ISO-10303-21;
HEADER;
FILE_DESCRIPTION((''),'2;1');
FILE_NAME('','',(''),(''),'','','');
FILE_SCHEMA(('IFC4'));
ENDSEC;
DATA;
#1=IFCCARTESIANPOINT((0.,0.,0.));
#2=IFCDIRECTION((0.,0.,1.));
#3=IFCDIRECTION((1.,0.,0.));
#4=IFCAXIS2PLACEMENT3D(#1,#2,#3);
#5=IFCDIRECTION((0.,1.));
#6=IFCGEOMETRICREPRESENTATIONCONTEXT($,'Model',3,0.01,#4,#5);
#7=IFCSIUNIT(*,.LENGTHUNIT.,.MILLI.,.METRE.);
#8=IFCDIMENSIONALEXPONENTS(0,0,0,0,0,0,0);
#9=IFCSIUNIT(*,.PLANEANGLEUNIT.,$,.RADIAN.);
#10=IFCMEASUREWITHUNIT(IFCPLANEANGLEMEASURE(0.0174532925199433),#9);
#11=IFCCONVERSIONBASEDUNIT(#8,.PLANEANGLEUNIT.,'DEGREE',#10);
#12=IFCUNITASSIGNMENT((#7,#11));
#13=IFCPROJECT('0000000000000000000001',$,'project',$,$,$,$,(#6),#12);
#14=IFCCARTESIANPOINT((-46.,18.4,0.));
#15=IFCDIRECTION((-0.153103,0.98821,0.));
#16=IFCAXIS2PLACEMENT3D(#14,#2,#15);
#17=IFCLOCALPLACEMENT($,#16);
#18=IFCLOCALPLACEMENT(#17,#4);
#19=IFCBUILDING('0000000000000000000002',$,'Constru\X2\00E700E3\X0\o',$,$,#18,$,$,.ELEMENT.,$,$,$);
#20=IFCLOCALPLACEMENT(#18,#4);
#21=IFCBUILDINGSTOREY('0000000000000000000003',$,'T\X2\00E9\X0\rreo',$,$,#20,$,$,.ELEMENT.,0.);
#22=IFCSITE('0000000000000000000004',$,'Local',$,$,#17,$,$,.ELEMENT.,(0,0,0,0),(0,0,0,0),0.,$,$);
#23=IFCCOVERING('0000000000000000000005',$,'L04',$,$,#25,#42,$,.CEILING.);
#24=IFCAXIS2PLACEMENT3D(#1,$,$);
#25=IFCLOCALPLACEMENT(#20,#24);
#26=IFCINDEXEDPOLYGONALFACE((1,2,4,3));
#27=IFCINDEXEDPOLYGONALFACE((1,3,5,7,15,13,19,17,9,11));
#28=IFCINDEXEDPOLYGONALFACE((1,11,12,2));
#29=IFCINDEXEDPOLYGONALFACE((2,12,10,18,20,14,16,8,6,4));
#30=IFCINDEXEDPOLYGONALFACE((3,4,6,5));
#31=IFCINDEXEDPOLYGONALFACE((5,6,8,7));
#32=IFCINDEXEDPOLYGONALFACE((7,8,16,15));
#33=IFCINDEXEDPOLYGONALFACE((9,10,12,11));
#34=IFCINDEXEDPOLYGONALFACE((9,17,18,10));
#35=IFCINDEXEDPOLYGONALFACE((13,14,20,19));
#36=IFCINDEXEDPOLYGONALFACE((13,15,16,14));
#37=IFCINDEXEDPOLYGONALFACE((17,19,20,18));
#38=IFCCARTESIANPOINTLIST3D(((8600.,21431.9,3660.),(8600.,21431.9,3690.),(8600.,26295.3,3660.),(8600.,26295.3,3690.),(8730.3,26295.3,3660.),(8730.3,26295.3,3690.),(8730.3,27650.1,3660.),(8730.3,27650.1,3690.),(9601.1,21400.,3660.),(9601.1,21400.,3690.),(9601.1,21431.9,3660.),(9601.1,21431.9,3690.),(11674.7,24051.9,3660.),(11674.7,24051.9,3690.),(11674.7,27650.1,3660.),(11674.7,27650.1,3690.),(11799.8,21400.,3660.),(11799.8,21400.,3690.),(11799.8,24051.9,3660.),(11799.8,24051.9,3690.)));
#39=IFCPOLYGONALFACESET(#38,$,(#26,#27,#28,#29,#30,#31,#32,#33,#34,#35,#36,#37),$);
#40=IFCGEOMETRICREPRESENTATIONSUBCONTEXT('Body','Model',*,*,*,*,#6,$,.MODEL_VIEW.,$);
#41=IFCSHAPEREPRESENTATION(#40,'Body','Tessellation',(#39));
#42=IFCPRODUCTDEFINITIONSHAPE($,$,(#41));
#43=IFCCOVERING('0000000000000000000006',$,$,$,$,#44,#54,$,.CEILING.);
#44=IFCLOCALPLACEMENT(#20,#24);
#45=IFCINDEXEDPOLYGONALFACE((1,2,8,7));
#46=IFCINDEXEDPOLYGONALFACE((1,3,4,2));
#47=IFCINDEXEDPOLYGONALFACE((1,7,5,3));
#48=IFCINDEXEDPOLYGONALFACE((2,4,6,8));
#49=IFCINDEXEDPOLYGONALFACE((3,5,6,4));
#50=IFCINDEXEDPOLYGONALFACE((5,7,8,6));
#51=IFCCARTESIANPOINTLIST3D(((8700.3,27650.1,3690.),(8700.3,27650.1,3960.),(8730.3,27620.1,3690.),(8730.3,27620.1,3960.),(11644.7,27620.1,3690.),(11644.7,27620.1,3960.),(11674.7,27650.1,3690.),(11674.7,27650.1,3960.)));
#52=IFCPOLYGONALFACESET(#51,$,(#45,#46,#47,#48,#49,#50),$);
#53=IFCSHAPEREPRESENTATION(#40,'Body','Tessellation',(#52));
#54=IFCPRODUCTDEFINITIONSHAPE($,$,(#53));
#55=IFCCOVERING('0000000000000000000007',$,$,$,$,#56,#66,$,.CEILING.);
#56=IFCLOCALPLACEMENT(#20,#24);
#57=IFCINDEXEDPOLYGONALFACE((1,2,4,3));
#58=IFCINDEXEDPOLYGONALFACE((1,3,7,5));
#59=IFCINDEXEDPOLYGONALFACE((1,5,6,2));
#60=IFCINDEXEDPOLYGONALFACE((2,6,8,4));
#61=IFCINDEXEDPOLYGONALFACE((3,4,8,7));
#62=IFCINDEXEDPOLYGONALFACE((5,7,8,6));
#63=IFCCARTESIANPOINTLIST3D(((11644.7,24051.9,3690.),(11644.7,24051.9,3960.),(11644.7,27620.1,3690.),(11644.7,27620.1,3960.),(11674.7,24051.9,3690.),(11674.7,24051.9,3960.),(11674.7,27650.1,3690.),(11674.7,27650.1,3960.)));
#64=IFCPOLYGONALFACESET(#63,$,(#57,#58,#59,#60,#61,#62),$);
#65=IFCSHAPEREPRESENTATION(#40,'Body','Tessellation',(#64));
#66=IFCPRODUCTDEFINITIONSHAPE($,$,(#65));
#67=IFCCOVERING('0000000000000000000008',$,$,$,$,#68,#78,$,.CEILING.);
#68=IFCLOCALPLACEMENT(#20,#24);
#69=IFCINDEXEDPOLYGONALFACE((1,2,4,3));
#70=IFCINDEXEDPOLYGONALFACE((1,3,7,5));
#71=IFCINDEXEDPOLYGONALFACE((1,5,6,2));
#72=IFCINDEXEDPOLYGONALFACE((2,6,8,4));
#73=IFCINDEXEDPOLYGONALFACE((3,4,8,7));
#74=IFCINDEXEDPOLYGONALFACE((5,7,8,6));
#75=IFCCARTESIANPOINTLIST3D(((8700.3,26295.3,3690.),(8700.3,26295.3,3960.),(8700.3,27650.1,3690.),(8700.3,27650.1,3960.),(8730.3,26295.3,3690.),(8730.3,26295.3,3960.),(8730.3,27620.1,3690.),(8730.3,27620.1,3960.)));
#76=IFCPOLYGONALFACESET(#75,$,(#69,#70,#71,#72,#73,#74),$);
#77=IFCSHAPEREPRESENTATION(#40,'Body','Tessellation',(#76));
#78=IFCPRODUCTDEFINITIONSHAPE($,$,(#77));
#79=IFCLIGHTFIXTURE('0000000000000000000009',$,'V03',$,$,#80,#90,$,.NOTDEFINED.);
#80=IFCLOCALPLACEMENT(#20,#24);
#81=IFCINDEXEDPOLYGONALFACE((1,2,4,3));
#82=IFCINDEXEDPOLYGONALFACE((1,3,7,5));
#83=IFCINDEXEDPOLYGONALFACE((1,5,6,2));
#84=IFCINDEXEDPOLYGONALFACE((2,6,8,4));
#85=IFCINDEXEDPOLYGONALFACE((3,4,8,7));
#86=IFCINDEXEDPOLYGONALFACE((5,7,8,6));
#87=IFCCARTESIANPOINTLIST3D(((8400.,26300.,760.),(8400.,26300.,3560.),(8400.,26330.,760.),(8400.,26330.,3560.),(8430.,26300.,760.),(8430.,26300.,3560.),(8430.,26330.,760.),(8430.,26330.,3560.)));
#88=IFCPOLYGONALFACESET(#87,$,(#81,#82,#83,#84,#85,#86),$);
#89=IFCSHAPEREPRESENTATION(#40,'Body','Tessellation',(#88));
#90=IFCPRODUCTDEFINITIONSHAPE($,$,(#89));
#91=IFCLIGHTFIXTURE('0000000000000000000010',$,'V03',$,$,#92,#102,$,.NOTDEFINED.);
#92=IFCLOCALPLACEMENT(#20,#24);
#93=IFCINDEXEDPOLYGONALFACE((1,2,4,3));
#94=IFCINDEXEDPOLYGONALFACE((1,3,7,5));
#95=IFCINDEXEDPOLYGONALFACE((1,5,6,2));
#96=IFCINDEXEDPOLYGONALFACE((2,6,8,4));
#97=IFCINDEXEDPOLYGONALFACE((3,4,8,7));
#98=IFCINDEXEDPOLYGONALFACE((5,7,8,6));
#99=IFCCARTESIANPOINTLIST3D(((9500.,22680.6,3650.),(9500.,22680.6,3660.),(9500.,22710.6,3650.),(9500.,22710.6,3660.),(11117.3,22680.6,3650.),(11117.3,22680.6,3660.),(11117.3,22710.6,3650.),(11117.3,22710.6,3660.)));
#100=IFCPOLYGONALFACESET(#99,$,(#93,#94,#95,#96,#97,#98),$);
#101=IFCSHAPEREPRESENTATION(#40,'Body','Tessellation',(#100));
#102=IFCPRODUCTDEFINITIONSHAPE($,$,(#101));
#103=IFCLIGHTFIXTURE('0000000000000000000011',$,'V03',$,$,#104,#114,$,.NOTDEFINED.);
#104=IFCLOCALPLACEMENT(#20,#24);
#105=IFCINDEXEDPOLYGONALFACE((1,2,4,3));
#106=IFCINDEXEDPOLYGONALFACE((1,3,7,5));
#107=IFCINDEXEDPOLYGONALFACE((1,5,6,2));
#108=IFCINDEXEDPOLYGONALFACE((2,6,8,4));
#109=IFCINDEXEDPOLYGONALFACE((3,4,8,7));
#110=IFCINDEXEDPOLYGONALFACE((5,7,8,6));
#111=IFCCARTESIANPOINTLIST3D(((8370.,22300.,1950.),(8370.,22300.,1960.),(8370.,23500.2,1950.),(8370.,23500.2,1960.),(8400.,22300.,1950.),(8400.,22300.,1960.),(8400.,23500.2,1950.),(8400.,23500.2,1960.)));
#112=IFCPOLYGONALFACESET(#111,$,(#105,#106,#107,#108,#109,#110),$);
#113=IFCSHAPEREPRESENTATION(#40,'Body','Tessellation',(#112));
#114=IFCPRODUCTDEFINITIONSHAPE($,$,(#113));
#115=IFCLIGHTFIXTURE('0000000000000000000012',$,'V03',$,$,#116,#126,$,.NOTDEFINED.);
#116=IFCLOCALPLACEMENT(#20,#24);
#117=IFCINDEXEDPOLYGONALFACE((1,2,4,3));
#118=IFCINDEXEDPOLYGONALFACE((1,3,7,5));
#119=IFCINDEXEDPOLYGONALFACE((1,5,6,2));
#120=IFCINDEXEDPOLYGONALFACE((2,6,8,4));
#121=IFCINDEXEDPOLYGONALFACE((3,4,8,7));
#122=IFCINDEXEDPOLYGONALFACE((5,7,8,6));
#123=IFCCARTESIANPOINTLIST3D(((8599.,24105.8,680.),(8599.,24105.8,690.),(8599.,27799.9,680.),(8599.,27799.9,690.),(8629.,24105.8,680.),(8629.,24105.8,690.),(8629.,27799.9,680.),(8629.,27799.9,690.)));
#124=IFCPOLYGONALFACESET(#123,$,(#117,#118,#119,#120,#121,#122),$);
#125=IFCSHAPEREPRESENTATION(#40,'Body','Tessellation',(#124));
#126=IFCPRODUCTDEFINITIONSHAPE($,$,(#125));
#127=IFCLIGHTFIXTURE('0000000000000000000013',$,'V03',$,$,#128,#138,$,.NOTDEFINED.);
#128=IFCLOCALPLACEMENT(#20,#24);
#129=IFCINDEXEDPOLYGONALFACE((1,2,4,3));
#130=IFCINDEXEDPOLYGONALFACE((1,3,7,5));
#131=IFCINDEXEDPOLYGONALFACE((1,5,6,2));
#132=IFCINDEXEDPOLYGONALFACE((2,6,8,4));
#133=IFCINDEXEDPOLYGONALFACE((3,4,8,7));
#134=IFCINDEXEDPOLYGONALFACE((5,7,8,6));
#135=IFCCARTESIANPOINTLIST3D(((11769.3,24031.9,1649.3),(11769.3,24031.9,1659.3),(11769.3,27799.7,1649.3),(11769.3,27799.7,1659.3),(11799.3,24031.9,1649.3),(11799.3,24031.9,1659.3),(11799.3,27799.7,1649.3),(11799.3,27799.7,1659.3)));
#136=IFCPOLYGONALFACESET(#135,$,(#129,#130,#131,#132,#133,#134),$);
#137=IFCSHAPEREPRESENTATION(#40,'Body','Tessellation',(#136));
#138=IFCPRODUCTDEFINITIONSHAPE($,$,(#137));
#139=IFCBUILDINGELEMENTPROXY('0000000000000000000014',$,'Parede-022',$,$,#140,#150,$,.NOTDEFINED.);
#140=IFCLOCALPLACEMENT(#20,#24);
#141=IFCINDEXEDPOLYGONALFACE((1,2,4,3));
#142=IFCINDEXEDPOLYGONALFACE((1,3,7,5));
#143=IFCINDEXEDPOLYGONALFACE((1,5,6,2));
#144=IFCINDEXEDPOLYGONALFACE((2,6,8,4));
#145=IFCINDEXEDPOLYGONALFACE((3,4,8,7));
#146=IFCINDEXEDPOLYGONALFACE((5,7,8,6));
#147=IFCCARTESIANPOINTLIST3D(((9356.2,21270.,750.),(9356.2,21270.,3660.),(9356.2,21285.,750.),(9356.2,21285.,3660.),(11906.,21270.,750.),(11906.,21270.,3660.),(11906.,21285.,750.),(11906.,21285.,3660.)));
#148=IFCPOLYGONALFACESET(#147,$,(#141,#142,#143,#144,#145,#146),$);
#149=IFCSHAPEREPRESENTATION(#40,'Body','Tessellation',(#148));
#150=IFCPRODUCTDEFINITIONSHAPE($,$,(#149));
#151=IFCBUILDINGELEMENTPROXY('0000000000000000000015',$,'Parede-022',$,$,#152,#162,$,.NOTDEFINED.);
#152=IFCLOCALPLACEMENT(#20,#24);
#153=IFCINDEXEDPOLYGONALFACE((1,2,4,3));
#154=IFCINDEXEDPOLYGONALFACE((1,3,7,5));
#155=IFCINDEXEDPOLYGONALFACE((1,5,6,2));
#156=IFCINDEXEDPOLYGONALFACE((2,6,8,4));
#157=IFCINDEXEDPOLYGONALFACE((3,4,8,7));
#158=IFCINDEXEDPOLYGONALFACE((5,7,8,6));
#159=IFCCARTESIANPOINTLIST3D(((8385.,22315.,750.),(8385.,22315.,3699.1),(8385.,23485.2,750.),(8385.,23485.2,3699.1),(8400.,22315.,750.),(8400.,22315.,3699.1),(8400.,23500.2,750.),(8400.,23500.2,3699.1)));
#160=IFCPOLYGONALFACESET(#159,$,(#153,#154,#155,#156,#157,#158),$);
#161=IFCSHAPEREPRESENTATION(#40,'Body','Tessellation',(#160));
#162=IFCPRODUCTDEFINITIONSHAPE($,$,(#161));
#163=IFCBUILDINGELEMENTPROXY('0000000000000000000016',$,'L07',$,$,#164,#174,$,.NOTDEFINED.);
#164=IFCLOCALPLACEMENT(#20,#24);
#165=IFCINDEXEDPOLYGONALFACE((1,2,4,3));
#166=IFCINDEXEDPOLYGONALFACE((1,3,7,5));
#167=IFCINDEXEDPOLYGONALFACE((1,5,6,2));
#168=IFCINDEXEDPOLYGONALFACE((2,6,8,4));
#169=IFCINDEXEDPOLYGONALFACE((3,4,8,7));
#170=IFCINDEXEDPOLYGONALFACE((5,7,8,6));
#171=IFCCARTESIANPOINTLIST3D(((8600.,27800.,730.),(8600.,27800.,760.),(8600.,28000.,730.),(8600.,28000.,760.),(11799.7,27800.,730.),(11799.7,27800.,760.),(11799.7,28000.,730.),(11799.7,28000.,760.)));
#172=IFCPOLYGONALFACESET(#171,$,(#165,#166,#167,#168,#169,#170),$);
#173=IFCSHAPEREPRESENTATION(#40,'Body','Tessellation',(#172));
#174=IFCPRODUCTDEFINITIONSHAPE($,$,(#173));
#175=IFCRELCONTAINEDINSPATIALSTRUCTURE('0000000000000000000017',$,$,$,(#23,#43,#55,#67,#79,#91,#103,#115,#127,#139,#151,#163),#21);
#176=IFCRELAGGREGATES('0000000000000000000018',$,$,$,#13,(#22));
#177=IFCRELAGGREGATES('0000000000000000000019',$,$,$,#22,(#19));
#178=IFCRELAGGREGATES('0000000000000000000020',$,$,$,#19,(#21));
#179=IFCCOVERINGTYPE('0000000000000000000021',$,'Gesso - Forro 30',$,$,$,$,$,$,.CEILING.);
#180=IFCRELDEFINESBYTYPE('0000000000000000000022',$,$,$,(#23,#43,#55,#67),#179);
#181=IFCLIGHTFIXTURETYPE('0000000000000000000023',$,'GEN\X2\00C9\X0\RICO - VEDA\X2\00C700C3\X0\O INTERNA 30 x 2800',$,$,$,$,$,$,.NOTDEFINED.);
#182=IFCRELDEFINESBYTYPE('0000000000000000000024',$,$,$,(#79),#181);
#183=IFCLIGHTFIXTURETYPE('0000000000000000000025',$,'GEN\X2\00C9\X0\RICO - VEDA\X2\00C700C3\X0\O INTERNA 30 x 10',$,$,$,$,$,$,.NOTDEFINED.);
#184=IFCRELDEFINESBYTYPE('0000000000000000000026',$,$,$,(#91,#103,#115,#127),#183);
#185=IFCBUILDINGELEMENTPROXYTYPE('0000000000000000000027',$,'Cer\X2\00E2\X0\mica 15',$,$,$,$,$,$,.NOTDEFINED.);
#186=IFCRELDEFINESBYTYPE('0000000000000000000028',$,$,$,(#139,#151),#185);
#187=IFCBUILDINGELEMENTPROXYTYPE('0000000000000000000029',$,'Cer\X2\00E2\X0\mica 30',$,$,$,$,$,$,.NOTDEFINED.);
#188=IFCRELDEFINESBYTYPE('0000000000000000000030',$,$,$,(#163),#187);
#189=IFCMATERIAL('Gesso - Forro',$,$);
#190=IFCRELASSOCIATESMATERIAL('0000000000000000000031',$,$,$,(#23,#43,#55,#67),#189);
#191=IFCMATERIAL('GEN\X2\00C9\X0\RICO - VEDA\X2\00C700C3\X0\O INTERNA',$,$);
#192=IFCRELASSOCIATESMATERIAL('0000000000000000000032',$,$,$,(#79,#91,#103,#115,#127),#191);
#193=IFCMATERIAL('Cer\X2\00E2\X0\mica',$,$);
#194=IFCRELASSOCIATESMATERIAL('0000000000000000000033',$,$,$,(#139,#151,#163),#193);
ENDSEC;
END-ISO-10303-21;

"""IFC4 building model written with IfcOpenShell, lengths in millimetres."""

from ifc_helpers import new_model, entity, si_unit, converted_unit, direction, frame, frame_2d, origin_with_axes, place, context, subcontext, project, spatial, line, indexed_curve, rectangle, outline, extrude, material, type_object, element, save


model = new_model("IFC4")

# Units and contexts
model_context = context("Model", 3, precision=0.01, world=origin_with_axes(), true_north=direction((0.0, 1.0)))
body_context = subcontext(model_context, "Body", "Model", "MODEL_VIEW")
ifc_project = project(units=[si_unit("LENGTHUNIT", "METRE", prefix="MILLI"), converted_unit("PLANEANGLEUNIT", "DEGREE", entity("IfcPlaneAngleMeasure", 0.0174532925199433), si_unit("PLANEANGLEUNIT", "RADIAN"), dimensions=[0, 0, 0, 0, 0, 0, 0])], contexts=[model_context])

# Site, building, storey
site_placement = place(None, frame((-46.0, 18.4, 0.0), z_axis=(0.0, 0.0, 1.0), x_axis=(-0.153103, 0.98821, 0.0)))
site = spatial("IfcSite", under=ifc_project, at=site_placement, Name="Local", CompositionType="ELEMENT", RefLatitude=(0, 0, 0, 0), RefLongitude=(0, 0, 0, 0), RefElevation=0.0)
building_placement = place(site_placement, origin_with_axes())
building = spatial("IfcBuilding", under=site, at=building_placement, Name="Construção", CompositionType="ELEMENT")
storey_placement = place(building_placement, origin_with_axes())
storey = spatial("IfcBuildingStorey", under=building, at=storey_placement, Name="Térreo", CompositionType="ELEMENT", Elevation=0.0)

# Shared definitions
ifc_material_1 = material(Name="GENÉRICO - VEDAÇÃO INTERNA")

# Coverings
ifc_material_2 = material(Name="Gesso - Forro")
covering_type_1 = type_object("IfcCoveringType", Name="Gesso - Forro 30", PredefinedType="CEILING")
covering_1_placement = place(storey_placement, frame((8730.3, 26295.3, 3690.0), z_axis=(0.0, 0.0, 1.0), x_axis=(1.0, 0.0, 0.0)))
element("IfcCovering", 1, at=covering_1_placement, inside=storey, type_object=covering_type_1, material=ifc_material_2, Name="L04", PredefinedType="CEILING", context=body_context, shape_type="SweptSolid", body=[
    extrude(outline(indexed_curve([(0.0, 0.0), (-130.3, 0.0), (-130.3, -4863.4), (870.8, -4863.4), (870.8, -4895.3), (3069.5, -4895.3), (3069.5, -2243.4), (2944.4, -2243.4), (2944.4, 1354.8), (0.0, 1354.8)], segments=[line(1, 2, 3, 4, 5, 6, 7, 8, 9, 10, 1)])), frame((0.0, 0.0, -30.0), z_axis=(0.0, 0.0, 1.0), x_axis=(1.0, 0.0, 0.0)), (0.0, 0.0, 1.0), 30.0),
])
covering_2_placement = place(storey_placement, frame((11674.7, 27650.1, 3690.0), z_axis=(0.0, 0.0, 1.0), x_axis=(-1.0, -0.000015, 0.0)))
element("IfcCovering", 2, at=covering_2_placement, inside=storey, type_object=covering_type_1, material=ifc_material_2, PredefinedType="CEILING", context=body_context, shape_type="SweptSolid", body=[
    extrude(outline(indexed_curve([(0.0, 0.0), (2974.4, 0.0), (2944.4, 30.0), (30.0, 30.0)], segments=[line(1, 2, 3, 4, 1)])), origin_with_axes(), (0.0, 0.0, 1.0), 270.0),
])
covering_3_placement = place(storey_placement, frame((11674.7, 24051.9, 3690.0), z_axis=(0.0, 0.0, 1.0), x_axis=(0.0, 1.0, 0.0)))
element("IfcCovering", 3, at=covering_3_placement, inside=storey, type_object=covering_type_1, material=ifc_material_2, PredefinedType="CEILING", context=body_context, shape_type="SweptSolid", body=[
    extrude(outline(indexed_curve([(0.0, 0.0), (3598.2, 0.0), (3568.2, 30.0), (0.0, 30.0)], segments=[line(1, 2, 3, 4, 1)])), origin_with_axes(), (0.0, 0.0, 1.0), 270.0),
])
covering_4_placement = place(storey_placement, frame((8700.3, 27650.1, 3690.0), z_axis=(0.0, 0.0, 1.0), x_axis=(0.000015, -1.0, 0.0)))
element("IfcCovering", 4, at=covering_4_placement, inside=storey, type_object=covering_type_1, material=ifc_material_2, PredefinedType="CEILING", context=body_context, shape_type="SweptSolid", body=[
    extrude(outline(indexed_curve([(0.0, 0.0), (1354.8, 0.0), (1354.8, 30.0), (30.0, 30.0)], segments=[line(1, 2, 3, 4, 1)])), origin_with_axes(), (0.0, 0.0, 1.0), 270.0),
])

# Light fixtures
light_fixture_type_1 = type_object("IfcLightFixtureType", Name="GENÉRICO - VEDAÇÃO INTERNA 30 x 2800", PredefinedType="NOTDEFINED")
light_fixture_1_placement = place(storey_placement, frame((8400.0, 26330.0, 3560.0), z_axis=(0.0, 0.0, 1.0), x_axis=(0.000002, -1.0, 0.0)))
element("IfcLightFixture", 5, at=light_fixture_1_placement, inside=storey, type_object=light_fixture_type_1, material=ifc_material_1, Name="V03", PredefinedType="NOTDEFINED", context=body_context, shape_type="SweptSolid", body=[
    extrude(rectangle(XDim=2800.0, YDim=30.0, at=frame_2d((-1400.0, 15.0), x_axis=(1.0, 0.0))), frame((0.0, 0.0, 0.0), z_axis=(0.0, 1.0, 0.0), x_axis=(0.0, 0.0, 1.0)), (0.0, 0.0, 1.0), 30.0),
])
light_fixture_type_2 = type_object("IfcLightFixtureType", Name="GENÉRICO - VEDAÇÃO INTERNA 30 x 10", PredefinedType="NOTDEFINED")
light_fixture_2_placement = place(storey_placement, frame((9500.0, 22710.6, 3660.0), z_axis=(0.0, 0.0, 1.0), x_axis=(0.0, -1.0, 0.0)))
element("IfcLightFixture", 6, at=light_fixture_2_placement, inside=storey, type_object=light_fixture_type_2, material=ifc_material_1, Name="V03", PredefinedType="NOTDEFINED", context=body_context, shape_type="SweptSolid", body=[
    extrude(rectangle(XDim=10.0, YDim=30.0, at=frame_2d((-5.0, 15.0), x_axis=(1.0, 0.0))), frame((0.0, 0.0, 0.0), z_axis=(0.0, 1.0, 0.0), x_axis=(0.0, 0.0, 1.0)), (0.0, 0.0, 1.0), 1617.4),
])
light_fixture_3_placement = place(storey_placement, frame((8400.0, 22300.0, 1960.0), z_axis=(0.0, 0.0, 1.0), x_axis=(1.0, 0.0, 0.0)))
element("IfcLightFixture", 7, at=light_fixture_3_placement, inside=storey, type_object=light_fixture_type_2, material=ifc_material_1, Name="V03", PredefinedType="NOTDEFINED", context=body_context, shape_type="SweptSolid", body=[
    extrude(rectangle(XDim=10.0, YDim=30.0, at=frame_2d((-5.0, -15.0), x_axis=(1.0, 0.0))), frame((0.0, 0.0, 0.0), z_axis=(0.0, 1.0, 0.0), x_axis=(0.0, 0.0, 1.0)), (0.0, 0.0, 1.0), 1200.2),
])
light_fixture_4_placement = place(storey_placement, frame((8629.0, 24105.8, 690.0), z_axis=(0.0, 0.0, 1.0), x_axis=(1.0, 0.0, 0.0)))
element("IfcLightFixture", 8, at=light_fixture_4_placement, inside=storey, type_object=light_fixture_type_2, material=ifc_material_1, Name="V03", PredefinedType="NOTDEFINED", context=body_context, shape_type="SweptSolid", body=[
    extrude(rectangle(XDim=10.0, YDim=30.0, at=frame_2d((-5.0, -15.0), x_axis=(1.0, 0.0))), frame((0.0, 0.0, 0.0), z_axis=(0.0, 1.0, 0.0), x_axis=(0.0, 0.0, 1.0)), (0.0, 0.0, 1.0), 3694.1),
])
light_fixture_5_placement = place(storey_placement, frame((11769.3, 27799.7, 1659.3), z_axis=(0.0, 0.0, 1.0), x_axis=(-1.0, 0.0, 0.0)))
element("IfcLightFixture", 9, at=light_fixture_5_placement, inside=storey, type_object=light_fixture_type_2, material=ifc_material_1, Name="V03", PredefinedType="NOTDEFINED", context=body_context, shape_type="SweptSolid", body=[
    extrude(rectangle(XDim=10.0, YDim=30.0, at=frame_2d((-5.0, -15.0), x_axis=(1.0, 0.0))), frame((0.0, 0.0, 0.0), z_axis=(0.0, 1.0, 0.0), x_axis=(0.0, 0.0, 1.0)), (0.0, 0.0, 1.0), 3767.8),
])

# Building element proxies
ifc_material_3 = material(Name="Cerâmica")
building_element_proxy_type_1 = type_object("IfcBuildingElementProxyType", Name="Cerâmica 15", PredefinedType="NOTDEFINED")
proxy_1_placement = place(storey_placement, frame((11906.0, 21285.0, 750.0), z_axis=(0.0, 0.0, 1.0), x_axis=(-1.0, 0.0, 0.0)))
element("IfcBuildingElementProxy", 10, at=proxy_1_placement, inside=storey, type_object=building_element_proxy_type_1, material=ifc_material_3, Name="Parede-022", PredefinedType="NOTDEFINED", context=body_context, shape_type="SweptSolid", body=[
    extrude(outline(indexed_curve([(0.0, 0.0), (2549.8, 0.0), (2549.8, 15.0), (0.0, 15.0)], segments=[line(1, 2, 3, 4, 1)])), origin_with_axes(), (0.0, 0.0, 1.0), 2910.0),
])
proxy_2_placement = place(storey_placement, frame((8400.0, 23500.2, 750.0), z_axis=(0.0, 0.0, 1.0), x_axis=(0.000001, -1.0, 0.0)))
element("IfcBuildingElementProxy", 11, at=proxy_2_placement, inside=storey, type_object=building_element_proxy_type_1, material=ifc_material_3, Name="Parede-022", PredefinedType="NOTDEFINED", context=body_context, shape_type="SweptSolid", body=[
    extrude(outline(indexed_curve([(15.0, -15.0), (1185.2, -15.0), (1185.2, 0.0), (0.0, 0.0)], segments=[line(1, 2, 3, 4, 1)])), origin_with_axes(), (0.0, 0.0, 1.0), 2949.1),
])
building_element_proxy_type_2 = type_object("IfcBuildingElementProxyType", Name="Cerâmica 30", PredefinedType="NOTDEFINED")
proxy_3_placement = place(storey_placement, frame((8600.0, 28000.0, 760.0), z_axis=(0.0, 0.0, 1.0), x_axis=(1.0, 0.0, 0.0)))
element("IfcBuildingElementProxy", 12, at=proxy_3_placement, inside=storey, type_object=building_element_proxy_type_2, material=ifc_material_3, Name="L07", PredefinedType="NOTDEFINED", context=body_context, shape_type="SweptSolid", body=[
    extrude(outline(indexed_curve([(0.0, 0.0), (0.0, -200.0), (3199.7, -200.0), (3199.7, 0.0)], segments=[line(1, 2, 3, 4, 1)])), frame((0.0, 0.0, -30.0), z_axis=(0.0, 0.0, 1.0), x_axis=(1.0, 0.0, 0.0)), (0.0, 0.0, 1.0), 30.0),
])

save(model, "model.ifc")
